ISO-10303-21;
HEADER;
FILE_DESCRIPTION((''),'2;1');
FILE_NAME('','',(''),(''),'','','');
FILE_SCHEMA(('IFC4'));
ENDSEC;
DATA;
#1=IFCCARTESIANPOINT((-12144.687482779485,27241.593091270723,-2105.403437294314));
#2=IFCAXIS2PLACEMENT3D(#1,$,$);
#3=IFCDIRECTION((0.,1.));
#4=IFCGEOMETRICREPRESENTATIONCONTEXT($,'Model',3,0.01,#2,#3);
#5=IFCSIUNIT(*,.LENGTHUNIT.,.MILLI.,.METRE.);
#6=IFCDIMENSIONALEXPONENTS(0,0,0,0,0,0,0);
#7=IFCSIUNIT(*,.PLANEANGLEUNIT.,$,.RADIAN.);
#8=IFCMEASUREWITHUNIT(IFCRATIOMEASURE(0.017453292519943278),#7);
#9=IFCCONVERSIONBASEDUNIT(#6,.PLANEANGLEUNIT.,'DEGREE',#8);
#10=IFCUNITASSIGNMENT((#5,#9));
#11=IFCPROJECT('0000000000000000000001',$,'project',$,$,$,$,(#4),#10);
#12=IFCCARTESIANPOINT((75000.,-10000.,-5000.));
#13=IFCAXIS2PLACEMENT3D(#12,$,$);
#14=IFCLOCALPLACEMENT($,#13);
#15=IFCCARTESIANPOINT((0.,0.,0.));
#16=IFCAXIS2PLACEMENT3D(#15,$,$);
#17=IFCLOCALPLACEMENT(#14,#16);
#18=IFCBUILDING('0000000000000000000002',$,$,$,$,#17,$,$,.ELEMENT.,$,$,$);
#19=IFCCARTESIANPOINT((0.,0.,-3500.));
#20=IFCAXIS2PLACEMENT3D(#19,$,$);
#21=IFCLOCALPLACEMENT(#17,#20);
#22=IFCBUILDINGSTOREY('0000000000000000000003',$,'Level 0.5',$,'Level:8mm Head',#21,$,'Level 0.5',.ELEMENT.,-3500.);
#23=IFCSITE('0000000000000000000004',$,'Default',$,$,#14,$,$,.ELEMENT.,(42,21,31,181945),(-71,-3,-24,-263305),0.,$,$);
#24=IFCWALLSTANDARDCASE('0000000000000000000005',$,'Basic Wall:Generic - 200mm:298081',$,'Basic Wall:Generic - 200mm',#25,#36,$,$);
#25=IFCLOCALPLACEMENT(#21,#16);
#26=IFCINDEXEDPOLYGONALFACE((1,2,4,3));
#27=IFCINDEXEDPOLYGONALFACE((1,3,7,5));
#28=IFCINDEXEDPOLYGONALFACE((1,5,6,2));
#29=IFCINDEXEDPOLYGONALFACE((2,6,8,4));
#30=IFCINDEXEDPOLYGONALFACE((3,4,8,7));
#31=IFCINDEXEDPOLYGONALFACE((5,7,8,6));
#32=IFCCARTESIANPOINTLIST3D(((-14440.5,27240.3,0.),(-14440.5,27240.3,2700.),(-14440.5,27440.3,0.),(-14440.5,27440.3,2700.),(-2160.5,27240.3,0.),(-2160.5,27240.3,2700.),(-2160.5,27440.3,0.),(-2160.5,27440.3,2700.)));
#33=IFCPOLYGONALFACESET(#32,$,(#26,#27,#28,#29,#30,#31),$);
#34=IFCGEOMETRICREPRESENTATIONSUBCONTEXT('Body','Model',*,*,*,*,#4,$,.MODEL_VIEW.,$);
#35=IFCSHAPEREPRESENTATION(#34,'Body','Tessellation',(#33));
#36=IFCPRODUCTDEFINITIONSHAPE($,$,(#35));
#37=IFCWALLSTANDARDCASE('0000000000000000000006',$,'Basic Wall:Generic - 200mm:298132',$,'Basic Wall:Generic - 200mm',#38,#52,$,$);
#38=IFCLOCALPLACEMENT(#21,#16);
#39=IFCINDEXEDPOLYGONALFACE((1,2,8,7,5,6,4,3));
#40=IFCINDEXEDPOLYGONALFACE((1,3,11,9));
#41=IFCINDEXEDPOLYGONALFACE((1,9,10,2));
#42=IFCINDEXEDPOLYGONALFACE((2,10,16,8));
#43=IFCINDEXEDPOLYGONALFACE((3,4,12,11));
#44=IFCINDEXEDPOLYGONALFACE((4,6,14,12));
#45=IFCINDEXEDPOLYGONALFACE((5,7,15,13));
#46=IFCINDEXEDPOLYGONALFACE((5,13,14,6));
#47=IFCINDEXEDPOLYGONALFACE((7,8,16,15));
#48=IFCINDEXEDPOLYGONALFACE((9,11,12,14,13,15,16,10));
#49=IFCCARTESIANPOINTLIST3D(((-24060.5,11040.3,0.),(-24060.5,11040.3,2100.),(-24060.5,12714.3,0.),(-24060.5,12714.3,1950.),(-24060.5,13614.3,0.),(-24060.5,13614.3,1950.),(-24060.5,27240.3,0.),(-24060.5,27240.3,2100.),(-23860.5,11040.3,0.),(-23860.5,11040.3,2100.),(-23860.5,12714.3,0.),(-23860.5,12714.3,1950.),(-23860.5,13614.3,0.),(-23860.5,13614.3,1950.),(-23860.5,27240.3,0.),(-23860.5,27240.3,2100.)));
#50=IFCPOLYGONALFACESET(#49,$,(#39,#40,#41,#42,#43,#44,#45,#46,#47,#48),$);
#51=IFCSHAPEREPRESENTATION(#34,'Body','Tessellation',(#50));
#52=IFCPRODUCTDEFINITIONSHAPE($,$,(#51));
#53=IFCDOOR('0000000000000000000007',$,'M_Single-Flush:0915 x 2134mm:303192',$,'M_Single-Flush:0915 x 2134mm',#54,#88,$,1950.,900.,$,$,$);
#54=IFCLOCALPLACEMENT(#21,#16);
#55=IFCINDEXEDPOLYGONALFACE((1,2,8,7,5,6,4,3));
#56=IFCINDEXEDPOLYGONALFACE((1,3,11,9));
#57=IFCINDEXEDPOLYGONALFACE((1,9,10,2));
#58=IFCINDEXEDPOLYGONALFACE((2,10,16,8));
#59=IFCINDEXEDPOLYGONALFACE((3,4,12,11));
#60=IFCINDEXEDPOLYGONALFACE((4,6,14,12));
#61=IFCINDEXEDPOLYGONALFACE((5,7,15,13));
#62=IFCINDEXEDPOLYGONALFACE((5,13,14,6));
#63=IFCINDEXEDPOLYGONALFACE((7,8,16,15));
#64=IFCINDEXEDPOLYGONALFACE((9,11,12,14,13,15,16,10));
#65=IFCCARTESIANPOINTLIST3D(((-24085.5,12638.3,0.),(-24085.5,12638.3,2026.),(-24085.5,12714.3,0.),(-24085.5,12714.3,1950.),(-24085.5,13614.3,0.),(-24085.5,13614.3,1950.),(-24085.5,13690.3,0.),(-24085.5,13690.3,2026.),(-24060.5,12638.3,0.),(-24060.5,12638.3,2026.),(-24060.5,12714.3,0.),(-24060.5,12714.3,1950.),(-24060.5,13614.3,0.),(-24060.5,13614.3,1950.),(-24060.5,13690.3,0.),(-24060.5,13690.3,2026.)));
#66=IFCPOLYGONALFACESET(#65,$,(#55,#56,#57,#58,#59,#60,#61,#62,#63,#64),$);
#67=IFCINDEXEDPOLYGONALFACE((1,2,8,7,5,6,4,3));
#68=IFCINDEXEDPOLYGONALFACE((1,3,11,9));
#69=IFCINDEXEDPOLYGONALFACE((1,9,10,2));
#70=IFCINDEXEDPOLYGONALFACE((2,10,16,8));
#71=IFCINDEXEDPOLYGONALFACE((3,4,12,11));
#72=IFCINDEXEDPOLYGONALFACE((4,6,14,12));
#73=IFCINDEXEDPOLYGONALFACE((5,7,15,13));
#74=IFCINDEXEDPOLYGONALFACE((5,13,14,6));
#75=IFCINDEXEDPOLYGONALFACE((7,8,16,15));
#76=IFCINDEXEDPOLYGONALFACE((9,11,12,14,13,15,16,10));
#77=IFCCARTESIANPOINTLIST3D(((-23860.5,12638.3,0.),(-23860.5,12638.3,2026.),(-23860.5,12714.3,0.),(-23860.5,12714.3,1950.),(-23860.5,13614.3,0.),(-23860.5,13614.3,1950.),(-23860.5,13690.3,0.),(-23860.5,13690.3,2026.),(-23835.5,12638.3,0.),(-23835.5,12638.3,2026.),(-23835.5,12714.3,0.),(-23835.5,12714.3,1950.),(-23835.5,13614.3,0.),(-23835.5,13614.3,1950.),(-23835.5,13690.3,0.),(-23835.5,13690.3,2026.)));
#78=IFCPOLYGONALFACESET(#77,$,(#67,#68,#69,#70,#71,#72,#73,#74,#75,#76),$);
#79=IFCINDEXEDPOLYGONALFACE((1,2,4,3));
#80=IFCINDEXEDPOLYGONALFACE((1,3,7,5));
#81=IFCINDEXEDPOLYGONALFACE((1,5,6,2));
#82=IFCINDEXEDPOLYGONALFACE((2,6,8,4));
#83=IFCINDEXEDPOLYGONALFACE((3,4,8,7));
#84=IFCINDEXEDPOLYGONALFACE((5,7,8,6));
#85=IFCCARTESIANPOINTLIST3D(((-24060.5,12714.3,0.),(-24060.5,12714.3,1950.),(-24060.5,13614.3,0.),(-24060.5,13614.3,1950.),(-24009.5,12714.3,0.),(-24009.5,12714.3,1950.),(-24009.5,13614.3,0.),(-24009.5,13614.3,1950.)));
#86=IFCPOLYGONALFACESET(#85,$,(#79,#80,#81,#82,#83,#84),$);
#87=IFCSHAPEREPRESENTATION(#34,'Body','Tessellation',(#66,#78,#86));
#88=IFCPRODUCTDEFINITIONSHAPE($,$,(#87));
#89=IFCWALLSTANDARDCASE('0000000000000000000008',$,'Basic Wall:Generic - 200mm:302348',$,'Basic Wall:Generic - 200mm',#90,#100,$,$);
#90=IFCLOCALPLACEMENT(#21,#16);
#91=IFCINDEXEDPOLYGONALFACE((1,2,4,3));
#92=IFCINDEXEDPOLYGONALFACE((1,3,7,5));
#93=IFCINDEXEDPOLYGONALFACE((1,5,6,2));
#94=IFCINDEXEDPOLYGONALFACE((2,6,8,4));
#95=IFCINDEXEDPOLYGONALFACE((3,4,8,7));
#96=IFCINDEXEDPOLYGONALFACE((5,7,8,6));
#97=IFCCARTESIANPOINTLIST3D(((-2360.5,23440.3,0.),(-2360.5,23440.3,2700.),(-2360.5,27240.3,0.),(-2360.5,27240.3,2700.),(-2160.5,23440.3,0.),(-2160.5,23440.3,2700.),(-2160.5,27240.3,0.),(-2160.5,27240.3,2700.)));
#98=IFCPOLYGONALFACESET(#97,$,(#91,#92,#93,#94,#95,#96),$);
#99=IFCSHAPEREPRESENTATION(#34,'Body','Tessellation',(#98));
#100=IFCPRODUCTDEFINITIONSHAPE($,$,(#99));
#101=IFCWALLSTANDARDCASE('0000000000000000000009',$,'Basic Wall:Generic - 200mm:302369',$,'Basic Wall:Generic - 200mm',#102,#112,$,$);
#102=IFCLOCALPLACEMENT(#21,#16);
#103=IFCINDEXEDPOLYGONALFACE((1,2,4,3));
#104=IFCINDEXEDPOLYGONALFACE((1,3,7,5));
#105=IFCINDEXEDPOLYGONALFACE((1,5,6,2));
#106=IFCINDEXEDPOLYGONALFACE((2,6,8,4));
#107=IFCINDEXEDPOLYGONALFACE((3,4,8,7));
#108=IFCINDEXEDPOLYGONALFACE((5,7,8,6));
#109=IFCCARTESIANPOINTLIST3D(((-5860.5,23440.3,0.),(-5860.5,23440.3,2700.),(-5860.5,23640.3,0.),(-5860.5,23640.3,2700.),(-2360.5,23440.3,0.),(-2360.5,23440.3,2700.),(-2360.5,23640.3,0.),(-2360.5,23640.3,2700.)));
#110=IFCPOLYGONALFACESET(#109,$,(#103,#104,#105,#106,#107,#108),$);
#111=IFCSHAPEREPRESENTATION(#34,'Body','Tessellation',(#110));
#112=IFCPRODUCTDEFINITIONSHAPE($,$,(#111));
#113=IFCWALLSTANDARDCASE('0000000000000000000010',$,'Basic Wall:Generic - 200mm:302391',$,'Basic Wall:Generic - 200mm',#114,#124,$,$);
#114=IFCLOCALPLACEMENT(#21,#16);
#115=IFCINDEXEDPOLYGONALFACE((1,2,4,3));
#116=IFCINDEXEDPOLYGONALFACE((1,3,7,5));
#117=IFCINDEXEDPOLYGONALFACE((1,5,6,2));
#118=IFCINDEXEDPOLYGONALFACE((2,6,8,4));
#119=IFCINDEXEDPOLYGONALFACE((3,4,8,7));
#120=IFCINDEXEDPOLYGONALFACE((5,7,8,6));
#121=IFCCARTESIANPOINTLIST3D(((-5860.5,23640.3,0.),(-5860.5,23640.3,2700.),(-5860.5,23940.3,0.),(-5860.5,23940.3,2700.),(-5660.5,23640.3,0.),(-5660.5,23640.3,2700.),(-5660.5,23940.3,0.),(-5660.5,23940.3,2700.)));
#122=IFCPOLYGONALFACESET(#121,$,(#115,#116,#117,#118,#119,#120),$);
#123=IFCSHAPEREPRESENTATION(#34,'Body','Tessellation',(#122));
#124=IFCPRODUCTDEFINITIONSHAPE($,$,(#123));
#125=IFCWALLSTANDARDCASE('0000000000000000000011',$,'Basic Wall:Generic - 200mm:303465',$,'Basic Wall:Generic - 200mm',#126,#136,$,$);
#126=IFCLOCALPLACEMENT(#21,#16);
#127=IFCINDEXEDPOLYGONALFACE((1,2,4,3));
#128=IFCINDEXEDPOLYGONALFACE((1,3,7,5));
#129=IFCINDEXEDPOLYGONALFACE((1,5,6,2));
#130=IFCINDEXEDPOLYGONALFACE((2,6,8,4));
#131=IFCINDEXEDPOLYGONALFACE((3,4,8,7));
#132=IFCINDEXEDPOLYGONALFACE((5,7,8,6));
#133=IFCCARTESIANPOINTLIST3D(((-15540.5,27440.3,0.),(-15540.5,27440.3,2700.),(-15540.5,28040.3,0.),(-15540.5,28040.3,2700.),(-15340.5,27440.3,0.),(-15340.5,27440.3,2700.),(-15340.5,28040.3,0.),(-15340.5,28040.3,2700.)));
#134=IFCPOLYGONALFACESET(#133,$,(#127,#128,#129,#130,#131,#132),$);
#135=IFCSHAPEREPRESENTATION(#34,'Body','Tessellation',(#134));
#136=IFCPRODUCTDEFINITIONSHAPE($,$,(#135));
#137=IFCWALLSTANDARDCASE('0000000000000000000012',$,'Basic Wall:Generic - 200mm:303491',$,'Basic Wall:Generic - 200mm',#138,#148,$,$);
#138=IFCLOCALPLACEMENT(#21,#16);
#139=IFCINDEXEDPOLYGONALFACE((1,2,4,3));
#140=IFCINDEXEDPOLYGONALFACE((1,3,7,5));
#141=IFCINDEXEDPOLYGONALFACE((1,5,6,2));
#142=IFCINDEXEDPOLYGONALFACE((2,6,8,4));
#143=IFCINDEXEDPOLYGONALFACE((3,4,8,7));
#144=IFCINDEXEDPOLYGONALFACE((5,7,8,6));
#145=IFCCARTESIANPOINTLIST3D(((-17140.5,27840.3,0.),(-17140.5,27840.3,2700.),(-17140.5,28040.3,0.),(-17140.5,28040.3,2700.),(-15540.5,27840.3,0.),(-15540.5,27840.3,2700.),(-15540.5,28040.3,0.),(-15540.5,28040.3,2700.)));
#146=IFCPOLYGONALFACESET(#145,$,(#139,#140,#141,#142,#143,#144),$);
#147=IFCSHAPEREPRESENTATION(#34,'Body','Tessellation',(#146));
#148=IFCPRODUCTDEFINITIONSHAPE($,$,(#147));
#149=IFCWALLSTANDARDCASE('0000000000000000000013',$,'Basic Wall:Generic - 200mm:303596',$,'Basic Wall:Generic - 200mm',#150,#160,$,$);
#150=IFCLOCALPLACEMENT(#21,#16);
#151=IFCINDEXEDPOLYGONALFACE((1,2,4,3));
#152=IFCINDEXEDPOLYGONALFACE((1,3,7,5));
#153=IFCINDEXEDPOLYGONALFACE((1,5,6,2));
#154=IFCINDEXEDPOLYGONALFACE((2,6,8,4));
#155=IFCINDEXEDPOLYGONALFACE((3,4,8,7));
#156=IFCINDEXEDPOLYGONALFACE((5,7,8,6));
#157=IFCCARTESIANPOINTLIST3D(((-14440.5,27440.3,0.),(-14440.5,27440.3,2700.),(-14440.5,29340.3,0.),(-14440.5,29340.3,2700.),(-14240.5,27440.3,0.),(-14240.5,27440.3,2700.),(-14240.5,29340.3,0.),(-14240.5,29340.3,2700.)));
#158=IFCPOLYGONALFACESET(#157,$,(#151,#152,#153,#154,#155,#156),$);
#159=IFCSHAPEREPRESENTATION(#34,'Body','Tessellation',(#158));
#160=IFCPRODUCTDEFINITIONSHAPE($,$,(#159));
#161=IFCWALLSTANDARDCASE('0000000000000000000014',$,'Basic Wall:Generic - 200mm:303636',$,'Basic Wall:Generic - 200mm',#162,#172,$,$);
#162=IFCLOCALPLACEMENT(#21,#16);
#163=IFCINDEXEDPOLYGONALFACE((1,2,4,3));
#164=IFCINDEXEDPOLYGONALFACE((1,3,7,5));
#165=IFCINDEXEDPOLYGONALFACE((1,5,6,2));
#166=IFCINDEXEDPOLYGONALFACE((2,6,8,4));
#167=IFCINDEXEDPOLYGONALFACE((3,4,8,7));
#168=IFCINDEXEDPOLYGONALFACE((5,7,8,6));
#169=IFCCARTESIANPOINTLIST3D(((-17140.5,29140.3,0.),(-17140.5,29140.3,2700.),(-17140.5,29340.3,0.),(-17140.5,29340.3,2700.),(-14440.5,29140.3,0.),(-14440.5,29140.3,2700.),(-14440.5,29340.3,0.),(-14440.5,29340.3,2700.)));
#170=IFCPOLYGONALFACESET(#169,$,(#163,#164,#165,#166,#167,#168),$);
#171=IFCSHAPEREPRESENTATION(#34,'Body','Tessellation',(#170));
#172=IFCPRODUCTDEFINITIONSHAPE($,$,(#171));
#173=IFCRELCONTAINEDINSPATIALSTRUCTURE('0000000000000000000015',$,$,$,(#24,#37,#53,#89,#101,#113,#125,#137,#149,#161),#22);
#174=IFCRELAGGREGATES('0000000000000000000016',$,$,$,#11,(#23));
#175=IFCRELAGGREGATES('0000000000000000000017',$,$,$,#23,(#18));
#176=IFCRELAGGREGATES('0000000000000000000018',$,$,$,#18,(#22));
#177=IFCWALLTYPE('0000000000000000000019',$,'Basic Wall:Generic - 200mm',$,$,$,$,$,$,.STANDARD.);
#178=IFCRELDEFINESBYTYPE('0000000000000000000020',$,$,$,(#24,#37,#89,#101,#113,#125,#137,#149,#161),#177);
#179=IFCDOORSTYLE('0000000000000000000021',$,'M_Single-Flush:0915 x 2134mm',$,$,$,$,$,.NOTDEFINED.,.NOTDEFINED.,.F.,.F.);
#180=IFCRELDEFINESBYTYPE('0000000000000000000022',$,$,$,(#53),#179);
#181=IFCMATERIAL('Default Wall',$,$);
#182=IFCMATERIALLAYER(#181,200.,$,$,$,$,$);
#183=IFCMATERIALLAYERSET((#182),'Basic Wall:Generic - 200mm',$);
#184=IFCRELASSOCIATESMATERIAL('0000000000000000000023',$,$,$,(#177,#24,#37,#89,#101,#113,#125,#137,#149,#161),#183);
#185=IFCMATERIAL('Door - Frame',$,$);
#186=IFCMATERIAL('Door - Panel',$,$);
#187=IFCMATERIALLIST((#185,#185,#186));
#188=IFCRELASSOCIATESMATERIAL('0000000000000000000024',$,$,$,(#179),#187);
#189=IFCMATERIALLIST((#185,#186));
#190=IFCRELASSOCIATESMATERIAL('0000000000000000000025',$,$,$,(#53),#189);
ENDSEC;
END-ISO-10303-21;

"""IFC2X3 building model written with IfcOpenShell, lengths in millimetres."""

from ifc_helpers import new_model, entity, si_unit, converted_unit, direction, frame, frame_2d, origin, place, context, subcontext, project, spatial, polyline, rectangle, outline, extrude, clip, bounded_halfspace, source, transform, mapped, material, material_list, layer, layer_set, layer_usage, type_object, type_shapes, element, fill, save


model = new_model("IFC2X3")

# Units and contexts
model_context = context("Model", 3, precision=0.01, world=frame((-12144.687482779485, 27241.593091270723, -2105.403437294314)), true_north=direction((0.0, 1.0)))
body_context = subcontext(model_context, "Body", "Model", "MODEL_VIEW")
ifc_project = project(units=[si_unit("LENGTHUNIT", "METRE", prefix="MILLI"), converted_unit("PLANEANGLEUNIT", "DEGREE", entity("IfcRatioMeasure", 0.017453292519943278), si_unit("PLANEANGLEUNIT", "RADIAN"), dimensions=[0, 0, 0, 0, 0, 0, 0])], contexts=[model_context])

# Site, building, storey
site_placement = place(None, frame((75000.0, -10000.0, -5000.0)))
site = spatial("IfcSite", under=ifc_project, at=site_placement, Name="Default", CompositionType="ELEMENT", RefLatitude=(42, 21, 31, 181945), RefLongitude=(-71, -3, -24, -263305), RefElevation=0.0)
building_placement = place(site_placement, origin())
building = spatial("IfcBuilding", under=site, at=building_placement, CompositionType="ELEMENT")
storey_placement = place(building_placement, frame((0.0, 0.0, -3500.0)))
storey = spatial("IfcBuildingStorey", under=building, at=storey_placement, Name="Level 0.5", ObjectType="Level:8mm Head", LongName="Level 0.5", CompositionType="ELEMENT", Elevation=-3500.0)

# Wall
ifc_material_1 = material(Name="Default Wall")
ifc_layer_1 = layer(ifc_material_1, 200.0)
ifc_layer_set_1 = layer_set([ifc_layer_1], Name="Basic Wall:Generic - 200mm")
wall_type_1 = type_object("IfcWallType", Name="Basic Wall:Generic - 200mm", PredefinedType="STANDARD", material=ifc_layer_set_1)
ifc_layer_usage_1 = layer_usage(ifc_layer_set_1, "AXIS2", "NEGATIVE", 100.0)
wall_1_placement = place(storey_placement, frame((-2160.5, 27340.3, 0.0), z_axis=(0.0, 0.0, 1.0), x_axis=(-1.0, 0.0, 0.0)))
element("IfcWallStandardCase", 1, at=wall_1_placement, inside=storey, type_object=wall_type_1, material=ifc_layer_usage_1, Name="Basic Wall:Generic - 200mm:298081", ObjectType="Basic Wall:Generic - 200mm", context=body_context, shape_type="SweptSolid", body=[
    extrude(rectangle(XDim=12280.0, YDim=200.0, at=frame_2d((6140.0, 0.0), x_axis=(-1.0, 0.0))), origin(), (0.0, 0.0, 1.0), 2700.0),
])

# Wall, opening, door
ifc_layer_usage_2 = layer_usage(ifc_layer_set_1, "AXIS2", "NEGATIVE", 100.0)
wall_2_placement = place(storey_placement, frame((-23960.5, 27240.3, 0.0), z_axis=(0.0, 0.0, 1.0), x_axis=(0.0, -1.0, 0.0)))
wall_2 = element("IfcWallStandardCase", 2, at=wall_2_placement, inside=storey, type_object=wall_type_1, material=ifc_layer_usage_2, Name="Basic Wall:Generic - 200mm:298132", ObjectType="Basic Wall:Generic - 200mm", context=body_context, shape_type="Clipping", body=[
    clip(extrude(rectangle(XDim=16200.0, YDim=200.0, at=frame_2d((8100.0, 0.0), x_axis=(1.0, 0.0))), origin(), (0.0, 0.0, 1.0), 2100.0), bounded_halfspace(frame((0.0, -100.0, 2100.0), z_axis=(0.0, 0.0, -1.0), x_axis=(1.0, 0.0, 0.0)), True, frame((0.0, -100.0, 2100.0)), polyline([(0.0, 0.0), (4884716.1, 0.0), (4937760.0, 0.0), (4937760.0, 60960.0), (0.0, 60960.0), (0.0, 0.0)]))),
])
opening_1_placement = place(wall_2_placement, frame((14526.0, 100.0, 0.0)))
opening_1 = element("IfcOpeningElement", 3, at=opening_1_placement, cuts=wall_2, ObjectType="Opening", context=body_context, shape_type="SweptSolid", body=[
    extrude(rectangle(XDim=900.0, YDim=1950.0, at=frame_2d((975.0, 450.0), x_axis=(0.0, -1.0))), frame((0.0, 0.0, 0.0), z_axis=(0.0, -1.0, 0.0), x_axis=(0.0, 0.0, 1.0)), (0.0, 0.0, 1.0), 200.0),
])
ifc_material_2 = material(Name="Door - Frame")
ifc_material_3 = material(Name="Door - Panel")
ifc_material_list_1 = material_list([ifc_material_2, ifc_material_3])
ifc_material_list_2 = material_list([ifc_material_2, ifc_material_2, ifc_material_3])
door_style = type_object("IfcDoorStyle", Name="M_Single-Flush:0915 x 2134mm", ConstructionType="NOTDEFINED", OperationType="NOTDEFINED", ParameterTakesPrecedence=False, Sizeable=False, material=ifc_material_list_2)
shared_shape_1 = source(origin(), body_context, "Body", "SweptSolid", [
    extrude(outline(polyline([(-526.0, -1032.0), (526.0, -1032.0), (526.0, 994.0), (450.0, 994.0), (450.0, -956.0), (-450.0, -956.0), (-450.0, 994.0), (-526.0, 994.0), (-526.0, -1032.0)])), frame((450.0, 225.0, 994.0), z_axis=(0.0, -1.0, 0.0), x_axis=(-1.0, 0.0, 0.0)), (0.0, 0.0, 1.0), 25.0),
    extrude(outline(polyline([(-1032.0, -526.0), (994.0, -526.0), (994.0, -450.0), (-956.0, -450.0), (-956.0, 450.0), (994.0, 450.0), (994.0, 526.0), (-1032.0, 526.0), (-1032.0, -526.0)])), frame((450.0, 0.0, 994.0), z_axis=(0.0, -1.0, 0.0), x_axis=(0.0, 0.0, -1.0)), (0.0, 0.0, 1.0), 25.0),
    extrude(rectangle(XDim=900.0, YDim=51.0, at=frame_2d((0.0, 0.0), x_axis=(1.0, 0.0))), frame((450.0, 174.5, 0.0)), (0.0, 0.0, 1.0), 1950.0),
])
type_shapes(door_style, [shared_shape_1])
door_placement = place(opening_1_placement, frame((0.0, 0.0, 0.0), z_axis=(0.0, 0.0, 1.0), x_axis=(-1.0, 0.0, 0.0)))
door = element("IfcDoor", 4, at=door_placement, inside=storey, type_object=door_style, material=ifc_material_list_1, Name="M_Single-Flush:0915 x 2134mm:303192", ObjectType="M_Single-Flush:0915 x 2134mm", OverallHeight=1950.0, OverallWidth=900.0, context=body_context, shape_type="MappedRepresentation", body=[
    mapped(shared_shape_1, transform((0.0, 0.0, 0.0), scale=1.0)),
])
fill(opening_1, door)

# Walls
ifc_layer_usage_3 = layer_usage(ifc_layer_set_1, "AXIS2", "NEGATIVE", 100.0)
wall_3_placement = place(storey_placement, frame((-2260.5, 27240.3, 0.0), z_axis=(0.0, 0.0, 1.0), x_axis=(0.0, -1.0, 0.0)))
element("IfcWallStandardCase", 5, at=wall_3_placement, inside=storey, type_object=wall_type_1, material=ifc_layer_usage_3, Name="Basic Wall:Generic - 200mm:302348", ObjectType="Basic Wall:Generic - 200mm", context=body_context, shape_type="SweptSolid", body=[
    extrude(rectangle(XDim=3800.0, YDim=200.0, at=frame_2d((1900.0, 0.0), x_axis=(-1.0, 0.0))), origin(), (0.0, 0.0, 1.0), 2700.0),
])
ifc_layer_usage_4 = layer_usage(ifc_layer_set_1, "AXIS2", "NEGATIVE", 100.0)
wall_4_placement = place(storey_placement, frame((-2360.5, 23540.3, 0.0), z_axis=(0.0, 0.0, 1.0), x_axis=(-1.0, 0.0, 0.0)))
element("IfcWallStandardCase", 6, at=wall_4_placement, inside=storey, type_object=wall_type_1, material=ifc_layer_usage_4, Name="Basic Wall:Generic - 200mm:302369", ObjectType="Basic Wall:Generic - 200mm", context=body_context, shape_type="SweptSolid", body=[
    extrude(rectangle(XDim=3500.0, YDim=200.0, at=frame_2d((1750.0, 0.0), x_axis=(-1.0, 0.0))), origin(), (0.0, 0.0, 1.0), 2700.0),
])
ifc_layer_usage_5 = layer_usage(ifc_layer_set_1, "AXIS2", "NEGATIVE", 100.0)
wall_5_placement = place(storey_placement, frame((-5760.5, 23640.3, 0.0), z_axis=(0.0, 0.0, 1.0), x_axis=(0.0, 1.0, 0.0)))
element("IfcWallStandardCase", 7, at=wall_5_placement, inside=storey, type_object=wall_type_1, material=ifc_layer_usage_5, Name="Basic Wall:Generic - 200mm:302391", ObjectType="Basic Wall:Generic - 200mm", context=body_context, shape_type="SweptSolid", body=[
    extrude(rectangle(XDim=300.0, YDim=200.0, at=frame_2d((150.0, 0.0), x_axis=(-1.0, 0.0))), origin(), (0.0, 0.0, 1.0), 2700.0),
])
ifc_layer_usage_6 = layer_usage(ifc_layer_set_1, "AXIS2", "NEGATIVE", 100.0)
wall_6_placement = place(storey_placement, frame((-15440.5, 27440.3, 0.0), z_axis=(0.0, 0.0, 1.0), x_axis=(0.0, 1.0, 0.0)))
element("IfcWallStandardCase", 8, at=wall_6_placement, inside=storey, type_object=wall_type_1, material=ifc_layer_usage_6, Name="Basic Wall:Generic - 200mm:303465", ObjectType="Basic Wall:Generic - 200mm", context=body_context, shape_type="SweptSolid", body=[
    extrude(rectangle(XDim=600.0, YDim=200.0, at=frame_2d((300.0, 0.0), x_axis=(-1.0, 0.0))), origin(), (0.0, 0.0, 1.0), 2700.0),
])
ifc_layer_usage_7 = layer_usage(ifc_layer_set_1, "AXIS2", "NEGATIVE", 100.0)
wall_7_placement = place(storey_placement, frame((-15540.5, 27940.3, 0.0), z_axis=(0.0, 0.0, 1.0), x_axis=(-1.0, 0.0, 0.0)))
element("IfcWallStandardCase", 9, at=wall_7_placement, inside=storey, type_object=wall_type_1, material=ifc_layer_usage_7, Name="Basic Wall:Generic - 200mm:303491", ObjectType="Basic Wall:Generic - 200mm", context=body_context, shape_type="SweptSolid", body=[
    extrude(rectangle(XDim=1600.0, YDim=200.0, at=frame_2d((800.0, 0.0), x_axis=(-1.0, 0.0))), origin(), (0.0, 0.0, 1.0), 2700.0),
])
ifc_layer_usage_8 = layer_usage(ifc_layer_set_1, "AXIS2", "NEGATIVE", 100.0)
wall_8_placement = place(storey_placement, frame((-14340.5, 27440.3, 0.0), z_axis=(0.0, 0.0, 1.0), x_axis=(0.0, 1.0, 0.0)))
element("IfcWallStandardCase", 10, at=wall_8_placement, inside=storey, type_object=wall_type_1, material=ifc_layer_usage_8, Name="Basic Wall:Generic - 200mm:303596", ObjectType="Basic Wall:Generic - 200mm", context=body_context, shape_type="SweptSolid", body=[
    extrude(rectangle(XDim=1900.0, YDim=200.0, at=frame_2d((950.0, 0.0), x_axis=(-1.0, 0.0))), origin(), (0.0, 0.0, 1.0), 2700.0),
])
ifc_layer_usage_9 = layer_usage(ifc_layer_set_1, "AXIS2", "NEGATIVE", 100.0)
wall_9_placement = place(storey_placement, frame((-14440.5, 29240.3, 0.0), z_axis=(0.0, 0.0, 1.0), x_axis=(-1.0, 0.0, 0.0)))
element("IfcWallStandardCase", 11, at=wall_9_placement, inside=storey, type_object=wall_type_1, material=ifc_layer_usage_9, Name="Basic Wall:Generic - 200mm:303636", ObjectType="Basic Wall:Generic - 200mm", context=body_context, shape_type="SweptSolid", body=[
    extrude(rectangle(XDim=2700.0, YDim=200.0, at=frame_2d((1350.0, 0.0), x_axis=(-1.0, 0.0))), origin(), (0.0, 0.0, 1.0), 2700.0),
])

save(model, "model.ifc")
